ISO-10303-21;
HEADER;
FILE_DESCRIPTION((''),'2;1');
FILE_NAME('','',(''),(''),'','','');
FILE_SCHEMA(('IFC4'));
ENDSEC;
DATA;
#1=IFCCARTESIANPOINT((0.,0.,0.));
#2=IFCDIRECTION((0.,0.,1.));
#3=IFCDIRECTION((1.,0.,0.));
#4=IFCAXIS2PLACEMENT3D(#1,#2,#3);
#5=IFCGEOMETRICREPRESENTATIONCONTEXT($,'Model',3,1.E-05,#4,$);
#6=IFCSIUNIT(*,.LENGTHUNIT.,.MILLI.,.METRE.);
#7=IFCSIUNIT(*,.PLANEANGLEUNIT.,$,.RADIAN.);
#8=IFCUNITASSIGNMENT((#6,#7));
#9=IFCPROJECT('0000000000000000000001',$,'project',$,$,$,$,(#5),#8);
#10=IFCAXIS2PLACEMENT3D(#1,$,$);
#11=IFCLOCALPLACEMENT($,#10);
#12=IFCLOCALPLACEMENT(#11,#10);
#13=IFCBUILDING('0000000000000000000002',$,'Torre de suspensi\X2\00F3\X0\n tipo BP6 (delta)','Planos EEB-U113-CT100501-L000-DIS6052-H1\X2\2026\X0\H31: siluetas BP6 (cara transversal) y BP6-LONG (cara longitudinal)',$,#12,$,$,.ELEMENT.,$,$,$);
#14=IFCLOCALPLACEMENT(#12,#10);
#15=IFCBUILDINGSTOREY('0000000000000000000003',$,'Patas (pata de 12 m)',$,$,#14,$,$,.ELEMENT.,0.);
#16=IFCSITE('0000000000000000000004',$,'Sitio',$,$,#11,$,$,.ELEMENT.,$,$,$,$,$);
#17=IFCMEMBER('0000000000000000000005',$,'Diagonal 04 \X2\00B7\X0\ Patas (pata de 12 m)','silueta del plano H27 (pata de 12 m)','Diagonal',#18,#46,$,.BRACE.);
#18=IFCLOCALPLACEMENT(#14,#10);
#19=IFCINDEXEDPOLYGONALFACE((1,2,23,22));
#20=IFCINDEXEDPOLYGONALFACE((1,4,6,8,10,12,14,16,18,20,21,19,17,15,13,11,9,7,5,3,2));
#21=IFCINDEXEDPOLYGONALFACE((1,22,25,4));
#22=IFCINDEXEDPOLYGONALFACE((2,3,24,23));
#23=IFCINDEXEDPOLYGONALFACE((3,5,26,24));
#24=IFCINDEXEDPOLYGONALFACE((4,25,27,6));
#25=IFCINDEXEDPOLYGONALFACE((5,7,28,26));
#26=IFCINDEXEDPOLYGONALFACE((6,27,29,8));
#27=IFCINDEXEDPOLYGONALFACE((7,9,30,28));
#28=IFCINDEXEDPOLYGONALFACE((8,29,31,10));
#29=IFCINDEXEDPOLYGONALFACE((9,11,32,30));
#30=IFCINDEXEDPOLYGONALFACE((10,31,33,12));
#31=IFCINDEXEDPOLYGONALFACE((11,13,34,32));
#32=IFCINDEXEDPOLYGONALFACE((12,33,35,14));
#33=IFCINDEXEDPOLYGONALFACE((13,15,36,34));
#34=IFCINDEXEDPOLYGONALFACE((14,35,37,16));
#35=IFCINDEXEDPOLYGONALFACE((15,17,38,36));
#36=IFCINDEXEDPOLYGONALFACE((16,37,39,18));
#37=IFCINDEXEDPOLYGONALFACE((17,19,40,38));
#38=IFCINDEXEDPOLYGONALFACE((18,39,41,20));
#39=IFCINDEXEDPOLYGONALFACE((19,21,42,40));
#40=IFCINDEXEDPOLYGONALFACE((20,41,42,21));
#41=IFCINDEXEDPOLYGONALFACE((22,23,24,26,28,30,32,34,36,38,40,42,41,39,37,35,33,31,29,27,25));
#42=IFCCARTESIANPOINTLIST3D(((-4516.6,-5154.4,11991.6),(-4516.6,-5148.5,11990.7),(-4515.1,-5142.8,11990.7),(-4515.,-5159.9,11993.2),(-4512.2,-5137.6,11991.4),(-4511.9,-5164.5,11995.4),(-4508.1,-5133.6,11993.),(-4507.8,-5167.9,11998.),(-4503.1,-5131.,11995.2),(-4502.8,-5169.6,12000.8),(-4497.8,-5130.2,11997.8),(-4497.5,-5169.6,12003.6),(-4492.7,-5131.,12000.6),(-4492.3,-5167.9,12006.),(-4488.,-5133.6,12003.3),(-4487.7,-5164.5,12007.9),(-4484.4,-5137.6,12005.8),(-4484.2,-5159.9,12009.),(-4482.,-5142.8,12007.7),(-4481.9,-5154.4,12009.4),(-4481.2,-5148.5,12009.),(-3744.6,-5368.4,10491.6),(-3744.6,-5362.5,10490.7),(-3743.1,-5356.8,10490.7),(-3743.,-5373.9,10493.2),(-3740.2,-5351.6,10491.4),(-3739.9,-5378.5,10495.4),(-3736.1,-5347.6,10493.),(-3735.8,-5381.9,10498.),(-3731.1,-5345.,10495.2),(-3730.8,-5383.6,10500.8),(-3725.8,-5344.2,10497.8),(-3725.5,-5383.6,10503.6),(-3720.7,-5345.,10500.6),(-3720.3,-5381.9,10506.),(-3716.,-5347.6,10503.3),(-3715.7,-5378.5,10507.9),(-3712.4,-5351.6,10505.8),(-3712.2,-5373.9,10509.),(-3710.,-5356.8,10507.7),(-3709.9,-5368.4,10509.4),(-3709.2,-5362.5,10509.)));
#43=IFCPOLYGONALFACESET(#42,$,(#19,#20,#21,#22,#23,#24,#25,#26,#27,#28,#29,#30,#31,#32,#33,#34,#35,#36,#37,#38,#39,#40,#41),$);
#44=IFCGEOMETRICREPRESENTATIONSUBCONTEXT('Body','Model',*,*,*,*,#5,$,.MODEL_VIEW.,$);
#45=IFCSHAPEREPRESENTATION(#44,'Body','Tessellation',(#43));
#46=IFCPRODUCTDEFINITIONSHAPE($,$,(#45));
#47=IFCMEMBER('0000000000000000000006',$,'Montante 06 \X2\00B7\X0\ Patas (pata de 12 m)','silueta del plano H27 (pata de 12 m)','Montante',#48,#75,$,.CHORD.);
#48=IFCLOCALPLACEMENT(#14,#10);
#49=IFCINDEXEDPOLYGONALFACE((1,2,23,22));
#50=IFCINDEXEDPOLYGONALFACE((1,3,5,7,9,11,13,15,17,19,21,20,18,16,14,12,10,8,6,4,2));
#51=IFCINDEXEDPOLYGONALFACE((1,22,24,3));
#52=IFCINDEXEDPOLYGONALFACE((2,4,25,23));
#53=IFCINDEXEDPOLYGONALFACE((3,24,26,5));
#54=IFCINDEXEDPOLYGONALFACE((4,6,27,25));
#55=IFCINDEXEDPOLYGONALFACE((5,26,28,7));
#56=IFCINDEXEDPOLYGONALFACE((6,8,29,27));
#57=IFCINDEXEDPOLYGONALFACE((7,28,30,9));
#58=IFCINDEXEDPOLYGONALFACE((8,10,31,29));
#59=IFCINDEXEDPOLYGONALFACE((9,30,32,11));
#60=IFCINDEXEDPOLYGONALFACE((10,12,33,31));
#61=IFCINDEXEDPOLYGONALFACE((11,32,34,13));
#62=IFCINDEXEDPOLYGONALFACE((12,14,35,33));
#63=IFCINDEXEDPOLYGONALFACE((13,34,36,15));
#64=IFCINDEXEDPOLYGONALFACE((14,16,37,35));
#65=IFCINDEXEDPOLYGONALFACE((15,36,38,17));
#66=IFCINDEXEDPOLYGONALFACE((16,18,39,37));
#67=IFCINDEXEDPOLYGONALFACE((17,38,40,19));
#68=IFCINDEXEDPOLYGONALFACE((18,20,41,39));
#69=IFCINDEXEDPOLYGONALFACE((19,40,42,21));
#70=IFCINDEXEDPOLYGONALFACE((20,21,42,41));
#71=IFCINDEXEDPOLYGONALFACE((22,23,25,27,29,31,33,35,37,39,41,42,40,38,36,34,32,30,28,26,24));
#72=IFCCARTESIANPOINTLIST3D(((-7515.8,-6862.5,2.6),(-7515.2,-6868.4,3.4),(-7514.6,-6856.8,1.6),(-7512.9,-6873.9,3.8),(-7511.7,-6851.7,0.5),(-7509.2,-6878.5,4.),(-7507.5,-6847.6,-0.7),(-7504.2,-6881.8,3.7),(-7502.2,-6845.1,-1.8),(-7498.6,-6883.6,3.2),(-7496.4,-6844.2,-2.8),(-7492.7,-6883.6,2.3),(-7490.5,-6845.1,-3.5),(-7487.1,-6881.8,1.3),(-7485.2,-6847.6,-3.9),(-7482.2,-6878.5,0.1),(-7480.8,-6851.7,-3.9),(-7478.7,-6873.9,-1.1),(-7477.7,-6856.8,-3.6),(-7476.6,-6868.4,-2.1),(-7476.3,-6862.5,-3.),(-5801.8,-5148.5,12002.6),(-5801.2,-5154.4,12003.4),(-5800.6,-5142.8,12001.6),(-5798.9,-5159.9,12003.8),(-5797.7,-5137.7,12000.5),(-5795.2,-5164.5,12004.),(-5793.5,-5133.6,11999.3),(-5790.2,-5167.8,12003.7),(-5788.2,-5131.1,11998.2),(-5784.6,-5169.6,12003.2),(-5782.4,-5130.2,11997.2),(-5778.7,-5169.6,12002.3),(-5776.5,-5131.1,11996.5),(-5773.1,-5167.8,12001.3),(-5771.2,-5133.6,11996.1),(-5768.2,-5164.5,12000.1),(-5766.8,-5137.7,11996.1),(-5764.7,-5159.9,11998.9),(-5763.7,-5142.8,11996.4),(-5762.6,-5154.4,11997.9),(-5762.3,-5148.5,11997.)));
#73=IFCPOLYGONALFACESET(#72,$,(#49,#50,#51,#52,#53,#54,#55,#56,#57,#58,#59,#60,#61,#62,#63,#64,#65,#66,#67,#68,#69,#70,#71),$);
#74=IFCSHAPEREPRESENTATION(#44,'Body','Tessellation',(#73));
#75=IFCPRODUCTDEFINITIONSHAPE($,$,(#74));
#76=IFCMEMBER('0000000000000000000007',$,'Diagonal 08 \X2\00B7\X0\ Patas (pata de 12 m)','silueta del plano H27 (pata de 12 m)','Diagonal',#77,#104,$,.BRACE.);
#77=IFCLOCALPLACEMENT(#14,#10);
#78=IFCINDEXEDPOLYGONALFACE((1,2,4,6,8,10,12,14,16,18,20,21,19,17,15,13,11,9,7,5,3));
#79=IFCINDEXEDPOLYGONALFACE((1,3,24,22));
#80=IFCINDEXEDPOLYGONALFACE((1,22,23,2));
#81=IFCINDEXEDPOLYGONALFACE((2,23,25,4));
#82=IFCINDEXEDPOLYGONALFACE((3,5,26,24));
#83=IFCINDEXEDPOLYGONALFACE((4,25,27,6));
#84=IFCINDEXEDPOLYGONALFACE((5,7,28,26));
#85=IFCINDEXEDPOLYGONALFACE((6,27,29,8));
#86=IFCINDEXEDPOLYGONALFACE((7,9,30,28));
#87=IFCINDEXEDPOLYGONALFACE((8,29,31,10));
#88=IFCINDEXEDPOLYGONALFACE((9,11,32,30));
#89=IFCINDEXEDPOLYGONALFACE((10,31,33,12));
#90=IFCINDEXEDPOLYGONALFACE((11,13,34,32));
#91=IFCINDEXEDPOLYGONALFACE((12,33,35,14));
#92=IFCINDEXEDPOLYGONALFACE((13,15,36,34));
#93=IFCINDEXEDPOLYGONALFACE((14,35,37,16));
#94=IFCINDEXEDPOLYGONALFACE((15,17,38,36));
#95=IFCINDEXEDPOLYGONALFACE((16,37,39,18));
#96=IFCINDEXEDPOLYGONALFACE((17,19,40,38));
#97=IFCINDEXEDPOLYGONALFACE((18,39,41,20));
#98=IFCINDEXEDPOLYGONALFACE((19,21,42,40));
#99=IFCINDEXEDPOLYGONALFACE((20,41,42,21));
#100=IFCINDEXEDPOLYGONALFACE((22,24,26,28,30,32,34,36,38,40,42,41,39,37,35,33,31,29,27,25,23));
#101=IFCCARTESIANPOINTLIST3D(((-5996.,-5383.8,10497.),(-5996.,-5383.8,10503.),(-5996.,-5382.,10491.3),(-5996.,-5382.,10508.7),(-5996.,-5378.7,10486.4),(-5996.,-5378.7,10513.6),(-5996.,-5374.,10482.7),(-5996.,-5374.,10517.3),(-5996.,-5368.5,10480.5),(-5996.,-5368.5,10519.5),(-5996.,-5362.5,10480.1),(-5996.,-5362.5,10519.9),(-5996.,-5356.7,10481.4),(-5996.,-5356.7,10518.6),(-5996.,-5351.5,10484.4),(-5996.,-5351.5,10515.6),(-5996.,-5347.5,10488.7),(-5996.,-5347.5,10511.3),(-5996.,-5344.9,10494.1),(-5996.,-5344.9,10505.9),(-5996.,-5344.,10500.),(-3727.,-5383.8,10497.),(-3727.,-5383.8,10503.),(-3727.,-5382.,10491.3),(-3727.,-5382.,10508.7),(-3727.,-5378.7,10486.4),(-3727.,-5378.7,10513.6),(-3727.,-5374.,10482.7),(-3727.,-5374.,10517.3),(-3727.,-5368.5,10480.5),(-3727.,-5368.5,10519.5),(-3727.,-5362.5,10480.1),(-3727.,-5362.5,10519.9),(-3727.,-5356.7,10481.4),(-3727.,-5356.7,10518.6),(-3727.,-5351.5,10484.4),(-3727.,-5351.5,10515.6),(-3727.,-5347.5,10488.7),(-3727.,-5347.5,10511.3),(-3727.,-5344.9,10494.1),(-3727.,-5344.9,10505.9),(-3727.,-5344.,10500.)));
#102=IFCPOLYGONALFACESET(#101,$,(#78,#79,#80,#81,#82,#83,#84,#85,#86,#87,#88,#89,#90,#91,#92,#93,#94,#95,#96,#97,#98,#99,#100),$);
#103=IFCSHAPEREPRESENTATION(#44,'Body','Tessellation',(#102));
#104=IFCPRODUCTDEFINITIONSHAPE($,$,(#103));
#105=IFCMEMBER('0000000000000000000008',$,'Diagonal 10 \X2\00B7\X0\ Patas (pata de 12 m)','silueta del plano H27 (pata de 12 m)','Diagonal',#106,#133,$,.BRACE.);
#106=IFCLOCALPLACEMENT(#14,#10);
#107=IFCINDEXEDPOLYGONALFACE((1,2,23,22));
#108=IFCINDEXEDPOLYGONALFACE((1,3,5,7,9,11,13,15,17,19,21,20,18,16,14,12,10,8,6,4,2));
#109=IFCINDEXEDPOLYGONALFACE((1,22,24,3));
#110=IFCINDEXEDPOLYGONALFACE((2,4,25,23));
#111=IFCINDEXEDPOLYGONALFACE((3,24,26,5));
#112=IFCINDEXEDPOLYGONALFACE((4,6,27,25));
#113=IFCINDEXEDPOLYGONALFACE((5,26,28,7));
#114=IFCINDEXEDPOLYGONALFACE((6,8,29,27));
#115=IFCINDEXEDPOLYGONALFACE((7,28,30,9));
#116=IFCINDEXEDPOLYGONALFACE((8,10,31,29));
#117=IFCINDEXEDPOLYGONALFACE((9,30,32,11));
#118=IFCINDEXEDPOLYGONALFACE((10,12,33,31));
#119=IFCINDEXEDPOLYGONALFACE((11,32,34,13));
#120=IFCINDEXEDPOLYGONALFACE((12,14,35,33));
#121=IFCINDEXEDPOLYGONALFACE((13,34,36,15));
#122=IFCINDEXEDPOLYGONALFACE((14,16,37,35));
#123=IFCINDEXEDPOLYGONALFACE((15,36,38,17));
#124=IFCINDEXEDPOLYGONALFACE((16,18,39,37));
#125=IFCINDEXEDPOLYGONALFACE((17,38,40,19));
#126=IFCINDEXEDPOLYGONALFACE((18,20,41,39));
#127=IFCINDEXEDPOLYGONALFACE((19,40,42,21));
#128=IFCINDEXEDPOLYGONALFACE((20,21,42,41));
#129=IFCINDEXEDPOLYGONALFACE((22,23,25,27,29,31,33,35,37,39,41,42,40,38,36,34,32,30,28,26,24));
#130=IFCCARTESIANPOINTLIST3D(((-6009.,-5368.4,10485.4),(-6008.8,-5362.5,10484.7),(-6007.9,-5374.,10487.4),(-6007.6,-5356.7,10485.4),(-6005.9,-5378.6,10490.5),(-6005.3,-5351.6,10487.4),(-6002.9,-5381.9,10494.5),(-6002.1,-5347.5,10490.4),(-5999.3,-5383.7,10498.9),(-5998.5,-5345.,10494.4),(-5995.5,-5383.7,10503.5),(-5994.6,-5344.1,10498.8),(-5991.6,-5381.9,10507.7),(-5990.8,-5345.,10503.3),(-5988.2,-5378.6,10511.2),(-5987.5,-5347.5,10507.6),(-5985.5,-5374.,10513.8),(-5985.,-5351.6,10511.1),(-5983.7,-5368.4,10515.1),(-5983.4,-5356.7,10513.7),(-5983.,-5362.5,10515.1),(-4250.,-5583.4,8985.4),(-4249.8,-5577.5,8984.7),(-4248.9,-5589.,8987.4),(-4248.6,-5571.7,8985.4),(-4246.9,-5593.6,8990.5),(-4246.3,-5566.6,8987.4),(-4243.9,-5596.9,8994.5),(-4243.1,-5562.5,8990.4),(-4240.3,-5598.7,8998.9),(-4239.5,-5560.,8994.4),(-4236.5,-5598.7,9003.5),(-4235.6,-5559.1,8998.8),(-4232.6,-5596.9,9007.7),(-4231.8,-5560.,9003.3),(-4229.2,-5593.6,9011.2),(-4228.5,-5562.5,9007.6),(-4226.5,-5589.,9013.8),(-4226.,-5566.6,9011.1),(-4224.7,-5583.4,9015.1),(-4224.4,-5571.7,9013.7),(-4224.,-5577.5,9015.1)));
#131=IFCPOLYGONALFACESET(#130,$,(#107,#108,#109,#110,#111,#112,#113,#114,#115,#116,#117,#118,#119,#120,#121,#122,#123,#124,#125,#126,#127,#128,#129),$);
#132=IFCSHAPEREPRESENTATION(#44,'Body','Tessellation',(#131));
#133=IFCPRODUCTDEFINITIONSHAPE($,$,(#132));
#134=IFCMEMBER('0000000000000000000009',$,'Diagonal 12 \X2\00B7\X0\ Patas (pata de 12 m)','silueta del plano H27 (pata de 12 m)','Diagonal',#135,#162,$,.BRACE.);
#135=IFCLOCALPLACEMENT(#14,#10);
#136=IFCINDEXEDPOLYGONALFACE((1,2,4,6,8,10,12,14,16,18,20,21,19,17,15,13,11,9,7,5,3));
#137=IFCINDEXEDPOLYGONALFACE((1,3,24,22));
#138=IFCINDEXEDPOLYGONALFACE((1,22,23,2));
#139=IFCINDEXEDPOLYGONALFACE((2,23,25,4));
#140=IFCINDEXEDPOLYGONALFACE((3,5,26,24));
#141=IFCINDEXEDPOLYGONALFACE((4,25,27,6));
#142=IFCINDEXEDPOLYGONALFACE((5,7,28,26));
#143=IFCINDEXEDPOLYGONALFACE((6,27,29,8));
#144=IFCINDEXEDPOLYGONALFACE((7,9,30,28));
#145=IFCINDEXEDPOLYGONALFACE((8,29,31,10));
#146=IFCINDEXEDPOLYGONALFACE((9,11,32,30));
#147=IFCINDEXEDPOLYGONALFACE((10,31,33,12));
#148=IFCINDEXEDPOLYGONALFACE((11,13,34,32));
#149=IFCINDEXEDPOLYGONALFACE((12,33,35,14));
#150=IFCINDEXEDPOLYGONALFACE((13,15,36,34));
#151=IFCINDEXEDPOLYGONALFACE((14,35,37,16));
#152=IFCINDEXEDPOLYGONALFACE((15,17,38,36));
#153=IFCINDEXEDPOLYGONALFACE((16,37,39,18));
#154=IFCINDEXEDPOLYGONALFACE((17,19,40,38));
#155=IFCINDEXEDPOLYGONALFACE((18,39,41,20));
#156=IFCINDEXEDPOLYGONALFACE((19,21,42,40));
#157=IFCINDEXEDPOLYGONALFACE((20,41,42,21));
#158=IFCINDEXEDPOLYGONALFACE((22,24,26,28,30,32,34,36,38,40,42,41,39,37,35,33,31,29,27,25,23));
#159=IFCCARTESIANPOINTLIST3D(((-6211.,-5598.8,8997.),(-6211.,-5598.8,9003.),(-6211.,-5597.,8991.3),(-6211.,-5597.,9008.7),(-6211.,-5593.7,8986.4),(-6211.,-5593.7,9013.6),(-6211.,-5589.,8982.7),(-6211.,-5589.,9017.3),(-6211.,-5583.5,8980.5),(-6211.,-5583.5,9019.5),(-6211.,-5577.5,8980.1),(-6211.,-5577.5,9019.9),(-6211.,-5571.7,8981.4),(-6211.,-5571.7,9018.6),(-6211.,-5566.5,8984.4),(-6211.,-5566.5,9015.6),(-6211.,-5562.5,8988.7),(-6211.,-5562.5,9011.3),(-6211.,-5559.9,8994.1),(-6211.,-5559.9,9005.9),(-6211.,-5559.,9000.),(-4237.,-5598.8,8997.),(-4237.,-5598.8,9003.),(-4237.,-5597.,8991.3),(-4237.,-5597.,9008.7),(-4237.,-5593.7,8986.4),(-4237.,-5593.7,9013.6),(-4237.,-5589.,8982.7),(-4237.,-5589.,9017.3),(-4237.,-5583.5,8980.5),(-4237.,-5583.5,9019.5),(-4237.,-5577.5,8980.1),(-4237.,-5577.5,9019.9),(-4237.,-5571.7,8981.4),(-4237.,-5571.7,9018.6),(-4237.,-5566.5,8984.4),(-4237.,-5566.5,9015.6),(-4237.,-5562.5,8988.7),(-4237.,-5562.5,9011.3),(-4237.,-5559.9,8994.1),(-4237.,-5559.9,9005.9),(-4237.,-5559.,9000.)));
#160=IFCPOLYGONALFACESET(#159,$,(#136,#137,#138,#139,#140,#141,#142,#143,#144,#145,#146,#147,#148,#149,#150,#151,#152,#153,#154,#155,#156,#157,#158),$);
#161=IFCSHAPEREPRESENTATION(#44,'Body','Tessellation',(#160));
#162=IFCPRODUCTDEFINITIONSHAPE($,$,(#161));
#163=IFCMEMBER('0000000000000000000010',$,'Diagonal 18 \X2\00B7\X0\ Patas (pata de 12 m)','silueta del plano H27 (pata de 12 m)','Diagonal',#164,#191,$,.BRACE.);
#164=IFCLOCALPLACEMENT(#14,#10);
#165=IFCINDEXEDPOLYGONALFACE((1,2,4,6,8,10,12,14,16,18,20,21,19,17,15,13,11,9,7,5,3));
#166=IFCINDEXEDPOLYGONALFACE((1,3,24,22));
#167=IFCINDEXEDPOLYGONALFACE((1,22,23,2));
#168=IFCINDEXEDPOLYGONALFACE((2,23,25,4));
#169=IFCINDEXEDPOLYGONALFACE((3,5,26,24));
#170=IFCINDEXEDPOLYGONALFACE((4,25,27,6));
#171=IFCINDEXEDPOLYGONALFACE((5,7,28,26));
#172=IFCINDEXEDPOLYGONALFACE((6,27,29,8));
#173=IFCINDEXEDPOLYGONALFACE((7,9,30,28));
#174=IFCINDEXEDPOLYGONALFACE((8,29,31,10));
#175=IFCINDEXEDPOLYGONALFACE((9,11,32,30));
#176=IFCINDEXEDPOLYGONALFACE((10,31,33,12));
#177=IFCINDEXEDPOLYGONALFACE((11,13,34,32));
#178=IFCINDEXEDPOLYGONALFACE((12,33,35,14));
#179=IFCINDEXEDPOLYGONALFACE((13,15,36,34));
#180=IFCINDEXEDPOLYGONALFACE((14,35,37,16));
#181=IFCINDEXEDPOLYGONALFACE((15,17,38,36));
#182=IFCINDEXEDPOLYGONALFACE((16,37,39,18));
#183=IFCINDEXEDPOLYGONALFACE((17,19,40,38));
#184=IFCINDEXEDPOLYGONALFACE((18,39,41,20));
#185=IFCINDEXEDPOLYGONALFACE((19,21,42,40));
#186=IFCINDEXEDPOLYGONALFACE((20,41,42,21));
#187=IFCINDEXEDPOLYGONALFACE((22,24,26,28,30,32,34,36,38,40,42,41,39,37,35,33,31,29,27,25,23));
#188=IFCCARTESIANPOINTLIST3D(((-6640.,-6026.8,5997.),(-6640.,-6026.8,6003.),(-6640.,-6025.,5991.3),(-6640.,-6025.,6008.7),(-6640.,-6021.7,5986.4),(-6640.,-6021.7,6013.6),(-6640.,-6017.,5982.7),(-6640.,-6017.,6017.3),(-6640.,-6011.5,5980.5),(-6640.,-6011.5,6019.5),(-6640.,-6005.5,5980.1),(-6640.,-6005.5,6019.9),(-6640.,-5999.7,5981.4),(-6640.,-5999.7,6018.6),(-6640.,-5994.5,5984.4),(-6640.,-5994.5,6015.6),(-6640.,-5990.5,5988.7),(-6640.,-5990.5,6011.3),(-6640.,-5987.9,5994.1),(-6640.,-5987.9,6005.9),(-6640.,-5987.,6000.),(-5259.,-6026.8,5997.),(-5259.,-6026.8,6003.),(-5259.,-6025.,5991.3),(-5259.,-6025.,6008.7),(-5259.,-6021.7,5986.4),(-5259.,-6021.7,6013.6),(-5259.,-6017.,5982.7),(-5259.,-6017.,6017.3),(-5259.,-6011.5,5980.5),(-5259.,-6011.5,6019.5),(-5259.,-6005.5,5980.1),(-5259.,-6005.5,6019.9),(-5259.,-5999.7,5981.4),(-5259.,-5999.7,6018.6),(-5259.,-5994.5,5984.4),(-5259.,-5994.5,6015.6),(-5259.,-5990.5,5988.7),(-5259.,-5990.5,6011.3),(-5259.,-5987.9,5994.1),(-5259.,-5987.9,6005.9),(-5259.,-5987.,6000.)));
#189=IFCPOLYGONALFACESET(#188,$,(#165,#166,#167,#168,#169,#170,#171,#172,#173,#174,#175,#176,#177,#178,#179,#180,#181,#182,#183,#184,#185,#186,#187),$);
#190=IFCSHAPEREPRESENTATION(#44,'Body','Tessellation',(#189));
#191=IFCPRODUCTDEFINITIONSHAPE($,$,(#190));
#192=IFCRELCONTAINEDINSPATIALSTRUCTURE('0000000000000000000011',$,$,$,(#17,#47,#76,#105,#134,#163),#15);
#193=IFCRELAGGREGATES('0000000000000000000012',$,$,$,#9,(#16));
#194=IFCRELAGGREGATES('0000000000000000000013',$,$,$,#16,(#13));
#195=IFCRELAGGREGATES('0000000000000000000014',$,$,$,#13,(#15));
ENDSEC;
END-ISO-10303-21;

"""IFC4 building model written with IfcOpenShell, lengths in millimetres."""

from ifc_helpers import new_model, si_unit, frame, origin, origin_with_axes, place, context, subcontext, project, spatial, circle, extrude, element, save


model = new_model("IFC4")

# Units and contexts
model_context = context("Model", 3, precision=1e-05, world=origin_with_axes())
body_context = subcontext(model_context, "Body", "Model", "MODEL_VIEW")
ifc_project = project(units=[si_unit("LENGTHUNIT", "METRE", prefix="MILLI"), si_unit("PLANEANGLEUNIT", "RADIAN")], contexts=[model_context])

# Site, building, storey
site_placement = place(None, origin())
site = spatial("IfcSite", under=ifc_project, at=site_placement, Name="Sitio", CompositionType="ELEMENT")
building_placement = place(site_placement, origin())
building = spatial("IfcBuilding", under=site, at=building_placement, Name="Torre de suspensión tipo BP6 (delta)", Description="Planos EEB-U113-CT100501-L000-DIS6052-H1…H31: siluetas BP6 (cara transversal) y BP6-LONG (cara longitudinal)", CompositionType="ELEMENT")
storey_placement = place(building_placement, origin())
storey = spatial("IfcBuildingStorey", under=building, at=storey_placement, Name="Patas (pata de 12 m)", CompositionType="ELEMENT", Elevation=0.0)

# Members
member_1_placement = place(storey_placement, frame((-4499.0, -5150.0, 12000.0), z_axis=(0.453978, -0.125844, -0.882081), x_axis=(0.057588, 0.99205, -0.111894)))
element("IfcMember", 1, at=member_1_placement, inside=storey, Name="Diagonal 04 · Patas (pata de 12 m)", Description="silueta del plano H27 (pata de 12 m)", ObjectType="Diagonal", PredefinedType="BRACE", context=body_context, shape_type="SweptSolid", body=[
    extrude(circle(Radius=20.0), None, (0.0, 0.0, 1.0), 1700.5),
])
member_2_placement = place(storey_placement, frame((-5782.0, -5150.0, 12000.0), z_axis=(-0.140006, -0.140006, -0.980202), x_axis=(-0.019797, 0.990151, -0.138599)))
element("IfcMember", 2, at=member_2_placement, inside=storey, Name="Montante 06 · Patas (pata de 12 m)", Description="silueta del plano H27 (pata de 12 m)", ObjectType="Montante", PredefinedType="CHORD", context=body_context, shape_type="SweptSolid", body=[
    extrude(circle(Radius=20.0), None, (0.0, 0.0, 1.0), 12242.4),
])
member_3_placement = place(storey_placement, frame((-3727.0, -5364.0, 10500.0), z_axis=(-1.0, 0.0, 0.0), x_axis=(0.0, 1.0, 0.0)))
element("IfcMember", 3, at=member_3_placement, inside=storey, Name="Diagonal 08 · Patas (pata de 12 m)", Description="silueta del plano H27 (pata de 12 m)", ObjectType="Diagonal", PredefinedType="BRACE", context=body_context, shape_type="SweptSolid", body=[
    extrude(circle(Radius=20.0), None, (0.0, 0.0, 1.0), 2269.0),
])
member_4_placement = place(storey_placement, frame((-4237.0, -5579.0, 9000.0), z_axis=(-0.757633, 0.092604, 0.646077), x_axis=(0.070463, 0.995703, -0.060088)))
element("IfcMember", 4, at=member_4_placement, inside=storey, Name="Diagonal 10 · Patas (pata de 12 m)", Description="silueta del plano H27 (pata de 12 m)", ObjectType="Diagonal", PredefinedType="BRACE", context=body_context, shape_type="SweptSolid", body=[
    extrude(circle(Radius=20.0), None, (0.0, 0.0, 1.0), 2321.7),
])
member_5_placement = place(storey_placement, frame((-6211.0, -5579.0, 9000.0), z_axis=(1.0, 0.0, 0.0), x_axis=(0.0, 1.0, 0.0)))
element("IfcMember", 5, at=member_5_placement, inside=storey, Name="Diagonal 12 · Patas (pata de 12 m)", Description="silueta del plano H27 (pata de 12 m)", ObjectType="Diagonal", PredefinedType="BRACE", context=body_context, shape_type="SweptSolid", body=[
    extrude(circle(Radius=20.0), None, (0.0, 0.0, 1.0), 1974.0),
])
member_6_placement = place(storey_placement, frame((-6640.0, -6007.0, 6000.0), z_axis=(1.0, 0.0, 0.0), x_axis=(0.0, 1.0, 0.0)))
element("IfcMember", 6, at=member_6_placement, inside=storey, Name="Diagonal 18 · Patas (pata de 12 m)", Description="silueta del plano H27 (pata de 12 m)", ObjectType="Diagonal", PredefinedType="BRACE", context=body_context, shape_type="SweptSolid", body=[
    extrude(circle(Radius=20.0), None, (0.0, 0.0, 1.0), 1381.0),
])

save(model, "model.ifc")
